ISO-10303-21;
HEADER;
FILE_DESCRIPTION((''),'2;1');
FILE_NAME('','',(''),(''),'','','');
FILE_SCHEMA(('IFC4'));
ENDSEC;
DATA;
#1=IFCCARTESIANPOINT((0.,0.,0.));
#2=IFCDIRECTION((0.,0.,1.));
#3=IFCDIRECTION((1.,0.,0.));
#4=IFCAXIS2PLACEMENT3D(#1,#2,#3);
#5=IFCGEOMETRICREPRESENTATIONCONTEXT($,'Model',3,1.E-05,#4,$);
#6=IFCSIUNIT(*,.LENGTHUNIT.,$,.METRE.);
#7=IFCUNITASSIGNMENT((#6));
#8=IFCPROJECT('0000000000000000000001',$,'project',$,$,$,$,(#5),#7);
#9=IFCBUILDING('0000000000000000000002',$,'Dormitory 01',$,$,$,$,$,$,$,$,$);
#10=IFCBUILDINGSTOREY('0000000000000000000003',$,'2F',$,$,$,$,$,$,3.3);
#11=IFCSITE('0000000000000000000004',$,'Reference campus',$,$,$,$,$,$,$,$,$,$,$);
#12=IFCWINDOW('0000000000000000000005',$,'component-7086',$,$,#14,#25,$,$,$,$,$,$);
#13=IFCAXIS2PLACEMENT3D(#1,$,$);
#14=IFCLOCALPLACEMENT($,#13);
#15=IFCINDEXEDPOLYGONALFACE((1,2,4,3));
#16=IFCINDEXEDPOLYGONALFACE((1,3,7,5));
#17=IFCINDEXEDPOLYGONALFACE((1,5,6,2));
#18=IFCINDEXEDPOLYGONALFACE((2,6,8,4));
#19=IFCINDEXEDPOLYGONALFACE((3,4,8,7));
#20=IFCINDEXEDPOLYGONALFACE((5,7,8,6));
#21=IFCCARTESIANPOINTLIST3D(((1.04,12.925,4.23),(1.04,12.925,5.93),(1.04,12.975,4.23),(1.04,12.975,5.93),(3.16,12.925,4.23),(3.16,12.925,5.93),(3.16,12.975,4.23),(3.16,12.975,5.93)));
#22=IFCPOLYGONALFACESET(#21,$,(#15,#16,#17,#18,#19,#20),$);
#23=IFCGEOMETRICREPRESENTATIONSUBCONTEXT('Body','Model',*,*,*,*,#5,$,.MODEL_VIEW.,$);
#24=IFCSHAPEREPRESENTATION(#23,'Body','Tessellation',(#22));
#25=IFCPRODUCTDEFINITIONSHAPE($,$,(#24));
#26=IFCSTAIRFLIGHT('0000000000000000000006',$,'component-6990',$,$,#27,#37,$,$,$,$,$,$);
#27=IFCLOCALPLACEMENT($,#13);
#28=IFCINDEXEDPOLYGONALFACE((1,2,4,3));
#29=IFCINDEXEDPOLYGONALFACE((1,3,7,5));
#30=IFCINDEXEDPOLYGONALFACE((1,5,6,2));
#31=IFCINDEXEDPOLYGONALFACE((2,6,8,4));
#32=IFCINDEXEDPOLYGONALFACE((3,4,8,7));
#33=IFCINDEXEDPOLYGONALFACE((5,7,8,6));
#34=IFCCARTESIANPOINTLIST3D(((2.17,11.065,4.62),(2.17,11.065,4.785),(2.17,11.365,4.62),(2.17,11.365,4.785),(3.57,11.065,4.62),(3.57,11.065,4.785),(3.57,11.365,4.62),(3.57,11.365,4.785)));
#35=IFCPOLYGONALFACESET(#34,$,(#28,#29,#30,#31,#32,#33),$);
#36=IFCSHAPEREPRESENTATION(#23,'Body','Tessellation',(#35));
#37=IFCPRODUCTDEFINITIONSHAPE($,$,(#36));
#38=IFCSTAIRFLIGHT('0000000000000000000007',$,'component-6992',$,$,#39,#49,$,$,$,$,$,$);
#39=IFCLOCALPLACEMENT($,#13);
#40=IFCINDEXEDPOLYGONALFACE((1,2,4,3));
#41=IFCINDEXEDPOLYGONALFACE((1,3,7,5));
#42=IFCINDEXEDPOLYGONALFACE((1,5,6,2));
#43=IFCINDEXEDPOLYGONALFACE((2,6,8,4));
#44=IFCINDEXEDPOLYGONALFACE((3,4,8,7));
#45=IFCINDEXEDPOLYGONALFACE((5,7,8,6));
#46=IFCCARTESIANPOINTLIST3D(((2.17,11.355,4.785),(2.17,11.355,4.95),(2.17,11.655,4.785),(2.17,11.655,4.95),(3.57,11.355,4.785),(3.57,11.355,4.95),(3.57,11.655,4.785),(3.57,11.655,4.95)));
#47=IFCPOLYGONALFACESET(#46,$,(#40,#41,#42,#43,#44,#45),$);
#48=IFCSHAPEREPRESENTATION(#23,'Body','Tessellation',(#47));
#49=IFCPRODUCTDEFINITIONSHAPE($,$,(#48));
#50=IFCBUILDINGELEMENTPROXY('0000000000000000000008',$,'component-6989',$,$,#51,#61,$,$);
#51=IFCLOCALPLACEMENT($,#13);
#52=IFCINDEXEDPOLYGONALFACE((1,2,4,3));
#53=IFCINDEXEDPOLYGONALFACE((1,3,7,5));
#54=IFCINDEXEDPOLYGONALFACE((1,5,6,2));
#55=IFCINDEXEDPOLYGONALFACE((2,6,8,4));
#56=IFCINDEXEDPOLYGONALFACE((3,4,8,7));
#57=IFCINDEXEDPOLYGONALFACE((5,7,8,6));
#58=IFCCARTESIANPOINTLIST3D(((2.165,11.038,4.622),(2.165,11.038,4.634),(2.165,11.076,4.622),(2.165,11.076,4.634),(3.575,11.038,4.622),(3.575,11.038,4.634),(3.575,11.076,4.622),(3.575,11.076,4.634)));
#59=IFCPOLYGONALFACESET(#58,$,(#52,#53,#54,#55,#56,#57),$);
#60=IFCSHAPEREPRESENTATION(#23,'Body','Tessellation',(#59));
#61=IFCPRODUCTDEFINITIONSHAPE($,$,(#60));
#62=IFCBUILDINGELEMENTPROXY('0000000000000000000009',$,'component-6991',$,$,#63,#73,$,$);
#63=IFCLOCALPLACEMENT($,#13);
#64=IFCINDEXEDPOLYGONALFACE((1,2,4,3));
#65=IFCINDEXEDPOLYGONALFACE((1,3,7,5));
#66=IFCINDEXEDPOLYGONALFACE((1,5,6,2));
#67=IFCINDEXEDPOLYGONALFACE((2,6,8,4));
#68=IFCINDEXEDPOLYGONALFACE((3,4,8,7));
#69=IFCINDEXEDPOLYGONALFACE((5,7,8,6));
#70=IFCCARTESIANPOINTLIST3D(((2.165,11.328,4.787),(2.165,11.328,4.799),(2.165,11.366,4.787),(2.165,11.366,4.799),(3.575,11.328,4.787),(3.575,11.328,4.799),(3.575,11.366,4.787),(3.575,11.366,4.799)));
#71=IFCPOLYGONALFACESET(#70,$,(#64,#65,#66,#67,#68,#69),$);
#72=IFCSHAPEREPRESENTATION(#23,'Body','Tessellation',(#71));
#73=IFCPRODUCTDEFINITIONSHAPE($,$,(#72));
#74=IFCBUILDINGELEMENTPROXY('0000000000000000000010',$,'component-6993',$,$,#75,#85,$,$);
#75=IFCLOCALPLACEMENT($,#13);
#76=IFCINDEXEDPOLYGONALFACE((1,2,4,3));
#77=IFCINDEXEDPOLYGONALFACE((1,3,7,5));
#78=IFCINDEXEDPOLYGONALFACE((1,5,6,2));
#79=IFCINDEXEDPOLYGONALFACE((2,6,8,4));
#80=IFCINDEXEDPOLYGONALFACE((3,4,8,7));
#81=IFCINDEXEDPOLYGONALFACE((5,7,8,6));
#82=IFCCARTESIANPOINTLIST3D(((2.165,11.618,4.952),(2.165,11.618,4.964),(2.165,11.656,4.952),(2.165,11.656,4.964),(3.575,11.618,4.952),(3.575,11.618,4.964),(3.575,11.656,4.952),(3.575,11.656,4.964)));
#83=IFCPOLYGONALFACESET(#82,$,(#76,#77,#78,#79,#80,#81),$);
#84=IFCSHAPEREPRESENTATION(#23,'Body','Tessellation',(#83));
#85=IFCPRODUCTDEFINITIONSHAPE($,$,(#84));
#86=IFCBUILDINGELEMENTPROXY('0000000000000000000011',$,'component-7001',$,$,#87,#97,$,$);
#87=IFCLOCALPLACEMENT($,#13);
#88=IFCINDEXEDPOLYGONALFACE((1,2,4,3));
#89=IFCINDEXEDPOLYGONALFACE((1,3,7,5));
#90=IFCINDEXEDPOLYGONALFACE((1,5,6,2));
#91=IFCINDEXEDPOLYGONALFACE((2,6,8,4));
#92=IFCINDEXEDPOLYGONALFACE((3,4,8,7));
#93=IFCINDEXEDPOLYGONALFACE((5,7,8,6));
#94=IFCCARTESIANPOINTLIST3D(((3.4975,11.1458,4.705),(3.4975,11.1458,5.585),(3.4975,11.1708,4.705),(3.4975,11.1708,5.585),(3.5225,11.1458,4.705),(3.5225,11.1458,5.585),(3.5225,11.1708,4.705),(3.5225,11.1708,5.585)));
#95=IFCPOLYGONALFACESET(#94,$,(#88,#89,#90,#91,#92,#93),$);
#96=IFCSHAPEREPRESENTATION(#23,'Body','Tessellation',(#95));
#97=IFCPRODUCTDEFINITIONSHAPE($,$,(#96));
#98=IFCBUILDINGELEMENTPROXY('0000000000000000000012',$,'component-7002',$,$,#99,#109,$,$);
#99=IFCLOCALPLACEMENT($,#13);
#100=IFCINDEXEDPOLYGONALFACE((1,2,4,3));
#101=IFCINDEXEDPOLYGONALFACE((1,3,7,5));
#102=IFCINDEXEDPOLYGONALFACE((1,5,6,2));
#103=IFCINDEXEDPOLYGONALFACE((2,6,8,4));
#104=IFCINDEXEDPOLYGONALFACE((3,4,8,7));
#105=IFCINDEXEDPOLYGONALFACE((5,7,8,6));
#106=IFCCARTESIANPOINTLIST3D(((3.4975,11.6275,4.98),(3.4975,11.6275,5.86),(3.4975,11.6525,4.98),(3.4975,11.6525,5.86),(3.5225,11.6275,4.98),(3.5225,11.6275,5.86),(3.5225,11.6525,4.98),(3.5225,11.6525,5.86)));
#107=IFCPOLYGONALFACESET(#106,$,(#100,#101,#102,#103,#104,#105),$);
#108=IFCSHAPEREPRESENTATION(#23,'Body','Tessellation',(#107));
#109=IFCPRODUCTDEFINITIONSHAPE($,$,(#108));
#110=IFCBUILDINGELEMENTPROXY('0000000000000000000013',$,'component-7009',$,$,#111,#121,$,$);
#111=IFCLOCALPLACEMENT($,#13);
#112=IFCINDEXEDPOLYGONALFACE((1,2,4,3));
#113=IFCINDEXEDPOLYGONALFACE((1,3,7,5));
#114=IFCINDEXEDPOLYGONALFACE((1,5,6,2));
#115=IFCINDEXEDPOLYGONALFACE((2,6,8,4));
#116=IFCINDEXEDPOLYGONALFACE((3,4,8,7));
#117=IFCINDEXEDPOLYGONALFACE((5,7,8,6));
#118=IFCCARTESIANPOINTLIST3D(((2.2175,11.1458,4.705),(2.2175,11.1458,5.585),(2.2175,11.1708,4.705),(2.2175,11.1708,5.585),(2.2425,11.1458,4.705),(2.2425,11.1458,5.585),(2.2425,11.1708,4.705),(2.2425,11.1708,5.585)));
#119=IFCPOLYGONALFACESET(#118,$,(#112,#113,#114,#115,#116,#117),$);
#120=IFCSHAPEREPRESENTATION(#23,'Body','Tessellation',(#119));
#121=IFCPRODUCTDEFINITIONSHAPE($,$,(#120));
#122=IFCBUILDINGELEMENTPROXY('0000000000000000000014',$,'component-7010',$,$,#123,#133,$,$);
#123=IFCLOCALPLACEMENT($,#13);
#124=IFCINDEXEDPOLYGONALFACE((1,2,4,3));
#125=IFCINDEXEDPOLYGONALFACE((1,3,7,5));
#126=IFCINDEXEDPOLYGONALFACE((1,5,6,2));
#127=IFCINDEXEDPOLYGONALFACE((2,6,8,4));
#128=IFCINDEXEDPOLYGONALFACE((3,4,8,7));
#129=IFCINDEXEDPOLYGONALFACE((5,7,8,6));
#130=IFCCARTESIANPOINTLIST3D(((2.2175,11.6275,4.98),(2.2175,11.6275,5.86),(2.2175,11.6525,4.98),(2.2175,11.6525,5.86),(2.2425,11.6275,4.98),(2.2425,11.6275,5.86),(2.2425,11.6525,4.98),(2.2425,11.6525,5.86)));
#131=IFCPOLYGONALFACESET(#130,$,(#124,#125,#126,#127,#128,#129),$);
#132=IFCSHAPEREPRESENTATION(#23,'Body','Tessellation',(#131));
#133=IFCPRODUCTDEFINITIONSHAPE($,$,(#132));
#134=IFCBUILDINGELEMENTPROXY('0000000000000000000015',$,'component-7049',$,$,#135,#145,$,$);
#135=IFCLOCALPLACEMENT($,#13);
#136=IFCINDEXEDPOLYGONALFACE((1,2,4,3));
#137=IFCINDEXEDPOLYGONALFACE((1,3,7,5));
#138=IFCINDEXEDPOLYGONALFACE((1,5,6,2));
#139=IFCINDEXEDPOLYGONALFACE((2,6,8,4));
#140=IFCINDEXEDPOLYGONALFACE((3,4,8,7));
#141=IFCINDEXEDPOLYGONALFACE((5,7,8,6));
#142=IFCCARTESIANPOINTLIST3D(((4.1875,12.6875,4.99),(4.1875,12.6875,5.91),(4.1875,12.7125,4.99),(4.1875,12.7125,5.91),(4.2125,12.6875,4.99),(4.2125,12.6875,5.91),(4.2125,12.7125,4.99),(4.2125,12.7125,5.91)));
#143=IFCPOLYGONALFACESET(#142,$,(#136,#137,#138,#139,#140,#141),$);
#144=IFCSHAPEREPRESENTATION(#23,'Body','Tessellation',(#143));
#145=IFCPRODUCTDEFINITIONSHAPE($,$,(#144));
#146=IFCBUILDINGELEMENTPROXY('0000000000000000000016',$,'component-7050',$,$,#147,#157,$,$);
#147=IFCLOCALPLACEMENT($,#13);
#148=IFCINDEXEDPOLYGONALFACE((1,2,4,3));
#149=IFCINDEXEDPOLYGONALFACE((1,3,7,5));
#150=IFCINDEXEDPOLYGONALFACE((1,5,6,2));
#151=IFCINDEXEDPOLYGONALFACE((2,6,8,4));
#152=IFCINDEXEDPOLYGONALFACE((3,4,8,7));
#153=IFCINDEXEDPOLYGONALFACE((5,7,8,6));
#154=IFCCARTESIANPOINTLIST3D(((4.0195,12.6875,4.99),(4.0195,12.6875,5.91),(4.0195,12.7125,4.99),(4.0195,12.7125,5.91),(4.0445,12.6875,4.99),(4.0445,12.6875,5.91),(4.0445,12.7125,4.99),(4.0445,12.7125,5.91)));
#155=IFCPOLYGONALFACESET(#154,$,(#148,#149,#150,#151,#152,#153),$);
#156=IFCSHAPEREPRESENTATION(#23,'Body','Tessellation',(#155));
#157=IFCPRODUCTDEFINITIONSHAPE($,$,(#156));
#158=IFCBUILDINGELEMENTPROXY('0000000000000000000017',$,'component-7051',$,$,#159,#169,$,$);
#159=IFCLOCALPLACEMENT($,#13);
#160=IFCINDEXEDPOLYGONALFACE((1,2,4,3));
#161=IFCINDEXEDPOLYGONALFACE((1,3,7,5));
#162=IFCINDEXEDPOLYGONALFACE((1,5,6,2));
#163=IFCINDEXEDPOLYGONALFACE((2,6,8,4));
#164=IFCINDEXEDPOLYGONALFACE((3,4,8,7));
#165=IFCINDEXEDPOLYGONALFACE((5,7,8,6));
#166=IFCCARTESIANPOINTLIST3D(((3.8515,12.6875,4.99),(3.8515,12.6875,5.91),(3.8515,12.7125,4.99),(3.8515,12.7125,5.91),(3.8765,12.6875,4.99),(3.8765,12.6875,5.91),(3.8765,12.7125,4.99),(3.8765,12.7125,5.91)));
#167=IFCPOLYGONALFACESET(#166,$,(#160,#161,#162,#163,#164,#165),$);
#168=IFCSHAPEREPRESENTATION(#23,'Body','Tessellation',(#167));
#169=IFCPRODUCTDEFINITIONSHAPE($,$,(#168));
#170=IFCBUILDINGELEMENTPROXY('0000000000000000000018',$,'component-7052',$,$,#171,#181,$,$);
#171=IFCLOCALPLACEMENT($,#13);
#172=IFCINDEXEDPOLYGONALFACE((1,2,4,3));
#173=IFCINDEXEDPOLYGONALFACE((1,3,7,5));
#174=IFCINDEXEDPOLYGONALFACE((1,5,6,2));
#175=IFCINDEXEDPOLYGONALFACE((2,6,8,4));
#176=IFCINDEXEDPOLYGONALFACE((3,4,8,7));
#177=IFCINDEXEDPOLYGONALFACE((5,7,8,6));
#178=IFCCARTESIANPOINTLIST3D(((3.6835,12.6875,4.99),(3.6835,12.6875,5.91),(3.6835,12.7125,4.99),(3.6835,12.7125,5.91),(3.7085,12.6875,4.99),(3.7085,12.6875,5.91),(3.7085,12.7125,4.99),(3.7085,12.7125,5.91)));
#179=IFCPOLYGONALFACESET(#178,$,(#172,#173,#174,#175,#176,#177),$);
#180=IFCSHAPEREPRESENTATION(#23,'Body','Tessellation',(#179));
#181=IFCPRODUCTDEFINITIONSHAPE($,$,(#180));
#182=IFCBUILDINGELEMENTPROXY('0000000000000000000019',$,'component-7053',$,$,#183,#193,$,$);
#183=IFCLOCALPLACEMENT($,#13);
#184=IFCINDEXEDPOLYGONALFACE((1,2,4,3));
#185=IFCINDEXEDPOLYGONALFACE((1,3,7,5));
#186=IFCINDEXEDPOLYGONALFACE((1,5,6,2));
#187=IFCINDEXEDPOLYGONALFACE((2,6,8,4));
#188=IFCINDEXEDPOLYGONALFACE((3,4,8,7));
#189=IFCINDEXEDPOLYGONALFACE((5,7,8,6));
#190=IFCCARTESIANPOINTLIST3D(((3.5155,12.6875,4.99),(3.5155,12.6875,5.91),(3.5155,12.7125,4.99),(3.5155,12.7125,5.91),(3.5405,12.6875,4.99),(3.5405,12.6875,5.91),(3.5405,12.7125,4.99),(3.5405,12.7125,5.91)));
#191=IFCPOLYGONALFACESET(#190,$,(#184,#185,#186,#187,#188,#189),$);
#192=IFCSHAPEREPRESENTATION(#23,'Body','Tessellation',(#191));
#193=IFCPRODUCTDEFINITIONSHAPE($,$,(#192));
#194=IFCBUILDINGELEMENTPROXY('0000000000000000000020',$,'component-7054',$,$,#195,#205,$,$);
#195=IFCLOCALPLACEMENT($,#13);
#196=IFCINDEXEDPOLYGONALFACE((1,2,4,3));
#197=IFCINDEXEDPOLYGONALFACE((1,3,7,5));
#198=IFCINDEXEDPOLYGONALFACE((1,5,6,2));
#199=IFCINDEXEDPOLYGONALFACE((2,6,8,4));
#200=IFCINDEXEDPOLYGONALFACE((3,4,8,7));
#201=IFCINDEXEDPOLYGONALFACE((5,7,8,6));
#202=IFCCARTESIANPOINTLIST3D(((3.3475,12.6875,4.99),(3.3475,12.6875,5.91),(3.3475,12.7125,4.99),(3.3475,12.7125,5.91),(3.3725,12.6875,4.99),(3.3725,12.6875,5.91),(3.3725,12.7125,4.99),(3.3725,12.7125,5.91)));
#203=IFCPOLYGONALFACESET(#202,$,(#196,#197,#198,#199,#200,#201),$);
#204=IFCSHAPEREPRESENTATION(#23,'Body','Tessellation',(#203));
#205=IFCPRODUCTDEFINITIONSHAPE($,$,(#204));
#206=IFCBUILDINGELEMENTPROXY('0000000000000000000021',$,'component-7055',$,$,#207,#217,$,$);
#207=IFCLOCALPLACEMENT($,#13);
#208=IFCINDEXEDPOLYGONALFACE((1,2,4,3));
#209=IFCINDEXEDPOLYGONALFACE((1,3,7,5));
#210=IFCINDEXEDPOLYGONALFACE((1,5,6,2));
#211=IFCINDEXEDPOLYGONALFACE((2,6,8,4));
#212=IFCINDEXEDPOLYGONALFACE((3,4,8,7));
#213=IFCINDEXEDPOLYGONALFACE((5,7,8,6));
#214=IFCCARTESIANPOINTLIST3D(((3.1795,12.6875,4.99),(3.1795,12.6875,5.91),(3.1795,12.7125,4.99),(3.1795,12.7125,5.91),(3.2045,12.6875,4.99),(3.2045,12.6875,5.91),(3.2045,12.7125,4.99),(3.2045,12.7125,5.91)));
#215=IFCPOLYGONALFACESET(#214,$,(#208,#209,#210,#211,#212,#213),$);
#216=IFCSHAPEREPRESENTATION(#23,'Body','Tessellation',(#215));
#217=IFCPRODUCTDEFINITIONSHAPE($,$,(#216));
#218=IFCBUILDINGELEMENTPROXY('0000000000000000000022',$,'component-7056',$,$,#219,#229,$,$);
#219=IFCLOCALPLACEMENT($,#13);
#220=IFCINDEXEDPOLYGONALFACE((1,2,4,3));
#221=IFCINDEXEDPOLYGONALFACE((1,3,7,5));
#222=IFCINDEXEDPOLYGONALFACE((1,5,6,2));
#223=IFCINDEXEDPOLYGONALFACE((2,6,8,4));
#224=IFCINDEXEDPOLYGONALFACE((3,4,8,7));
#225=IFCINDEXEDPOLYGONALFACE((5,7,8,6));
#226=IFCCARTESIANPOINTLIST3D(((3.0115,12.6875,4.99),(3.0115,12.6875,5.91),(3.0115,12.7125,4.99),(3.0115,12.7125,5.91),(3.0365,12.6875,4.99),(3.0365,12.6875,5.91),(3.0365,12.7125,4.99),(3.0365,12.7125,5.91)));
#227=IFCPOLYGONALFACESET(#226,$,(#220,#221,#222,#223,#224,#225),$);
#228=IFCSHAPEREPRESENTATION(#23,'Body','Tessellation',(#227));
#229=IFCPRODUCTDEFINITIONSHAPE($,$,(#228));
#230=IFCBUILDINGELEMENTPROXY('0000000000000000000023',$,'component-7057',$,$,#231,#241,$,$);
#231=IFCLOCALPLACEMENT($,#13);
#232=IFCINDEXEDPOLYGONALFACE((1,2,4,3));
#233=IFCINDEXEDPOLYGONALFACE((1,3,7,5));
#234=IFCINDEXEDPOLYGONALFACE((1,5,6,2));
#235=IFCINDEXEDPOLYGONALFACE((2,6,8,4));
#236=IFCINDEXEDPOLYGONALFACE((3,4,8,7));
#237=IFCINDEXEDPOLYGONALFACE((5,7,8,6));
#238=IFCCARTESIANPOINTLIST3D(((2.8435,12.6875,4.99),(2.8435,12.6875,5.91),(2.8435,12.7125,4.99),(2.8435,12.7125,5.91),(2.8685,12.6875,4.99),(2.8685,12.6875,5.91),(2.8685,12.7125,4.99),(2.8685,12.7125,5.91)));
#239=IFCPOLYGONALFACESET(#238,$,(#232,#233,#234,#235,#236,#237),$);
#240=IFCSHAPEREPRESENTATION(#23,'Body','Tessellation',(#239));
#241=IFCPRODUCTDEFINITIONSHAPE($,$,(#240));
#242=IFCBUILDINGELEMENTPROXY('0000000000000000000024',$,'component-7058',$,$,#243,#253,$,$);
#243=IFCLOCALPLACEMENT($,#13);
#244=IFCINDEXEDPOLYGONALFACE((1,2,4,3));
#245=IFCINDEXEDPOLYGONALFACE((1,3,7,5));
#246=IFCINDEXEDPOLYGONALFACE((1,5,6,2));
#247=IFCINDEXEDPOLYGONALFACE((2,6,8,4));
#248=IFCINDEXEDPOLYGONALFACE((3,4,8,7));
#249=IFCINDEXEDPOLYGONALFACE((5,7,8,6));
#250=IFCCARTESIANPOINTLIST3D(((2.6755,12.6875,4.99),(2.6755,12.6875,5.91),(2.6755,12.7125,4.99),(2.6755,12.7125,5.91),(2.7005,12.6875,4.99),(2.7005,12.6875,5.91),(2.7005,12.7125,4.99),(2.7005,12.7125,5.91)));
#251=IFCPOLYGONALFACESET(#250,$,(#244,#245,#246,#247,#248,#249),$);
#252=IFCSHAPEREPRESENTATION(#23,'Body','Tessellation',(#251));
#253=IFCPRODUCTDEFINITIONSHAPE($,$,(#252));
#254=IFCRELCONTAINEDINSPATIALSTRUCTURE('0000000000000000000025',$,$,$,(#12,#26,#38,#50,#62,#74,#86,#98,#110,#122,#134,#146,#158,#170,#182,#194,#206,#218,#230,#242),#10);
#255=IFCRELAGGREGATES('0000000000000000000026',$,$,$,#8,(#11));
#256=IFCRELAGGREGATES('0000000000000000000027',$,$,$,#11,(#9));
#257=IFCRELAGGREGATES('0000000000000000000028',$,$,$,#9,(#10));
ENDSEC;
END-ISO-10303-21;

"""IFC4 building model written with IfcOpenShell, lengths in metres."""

from ifc_helpers import new_model, si_unit, frame, origin, origin_with_axes, origin_2d, place, context, subcontext, project, spatial, rectangle, extrude, element, save


model = new_model("IFC4")

# Units and contexts
model_context = context("Model", 3, precision=1e-05, world=origin_with_axes())
body_context = subcontext(model_context, "Body", "Model", "MODEL_VIEW")
ifc_project = project(units=[si_unit("LENGTHUNIT", "METRE")], contexts=[model_context])

# Site, building, storey
site = spatial("IfcSite", under=ifc_project, Name="Reference campus")
building = spatial("IfcBuilding", under=site, Name="Dormitory 01")
storey = spatial("IfcBuildingStorey", under=building, Name="2F", Elevation=3.3)

# Window
window_placement = place(None, frame((2.1, 12.95, 4.23), z_axis=(0.0, 0.0, 1.0), x_axis=(-1.0, 0.0, 0.0)))
element("IfcWindow", 1, at=window_placement, inside=storey, Name="component-7086", context=body_context, shape_type="SweptSolid", body=[
    extrude(rectangle(XDim=2.12, YDim=0.05, at=origin_2d()), origin(), (0.0, 0.0, 1.0), 1.7),
])

# Stair flights
for number, where, z_axis, x_axis, name in (
    (2, (2.87, 11.215, 4.62), (0.0, 0.0, 1.0), (-1.0, 0.0, 0.0), "component-6990"),
    (3, (2.87, 11.505, 4.785), (0.0, 0.0, 1.0), (-1.0, 0.0, 0.0), "component-6992"),
):
    element("IfcStairFlight", number, at=place(None, frame(where, z_axis=z_axis, x_axis=x_axis)), inside=storey, Name=name, context=body_context, shape_type="SweptSolid", body=[
        extrude(rectangle(XDim=1.4, YDim=0.3, at=origin_2d()), origin(), (0.0, 0.0, 1.0), 0.165),
    ])

# Building element proxies
for number, where, z_axis, x_axis, name in (
    (4, (2.87, 11.057, 4.622), (0.0, 0.0, 1.0), (-1.0, 0.0, 0.0), "component-6989"),
    (5, (2.87, 11.347, 4.787), (0.0, 0.0, 1.0), (-1.0, 0.0, 0.0), "component-6991"),
    (6, (2.87, 11.637, 4.952), (0.0, 0.0, 1.0), (-1.0, 0.0, 0.0), "component-6993"),
):
    element("IfcBuildingElementProxy", number, at=place(None, frame(where, z_axis=z_axis, x_axis=x_axis)), inside=storey, Name=name, context=body_context, shape_type="SweptSolid", body=[
        extrude(rectangle(XDim=1.41, YDim=0.038, at=origin_2d()), origin(), (0.0, 0.0, 1.0), 0.012),
    ])
for number, where, z_axis, x_axis, name in (
    (7, (3.51, 11.1583, 4.705), (0.0, 0.0, 1.0), (-1.0, 0.0, 0.0), "component-7001"),
    (8, (3.51, 11.64, 4.98), (0.0, 0.0, 1.0), (-1.0, 0.0, 0.0), "component-7002"),
    (9, (2.23, 11.1583, 4.705), (0.0, 0.0, 1.0), (-1.0, 0.0, 0.0), "component-7009"),
    (10, (2.23, 11.64, 4.98), (0.0, 0.0, 1.0), (-1.0, 0.0, 0.0), "component-7010"),
):
    element("IfcBuildingElementProxy", number, at=place(None, frame(where, z_axis=z_axis, x_axis=x_axis)), inside=storey, Name=name, context=body_context, shape_type="SweptSolid", body=[
        extrude(rectangle(XDim=0.025, YDim=0.025, at=origin_2d()), origin(), (0.0, 0.0, 1.0), 0.88),
    ])
for number, where, z_axis, x_axis, name in (
    (11, (4.2, 12.7, 4.99), (0.0, 0.0, 1.0), (-1.0, 0.0, 0.0), "component-7049"),
    (12, (4.032, 12.7, 4.99), (0.0, 0.0, 1.0), (-1.0, 0.0, 0.0), "component-7050"),
    (13, (3.864, 12.7, 4.99), (0.0, 0.0, 1.0), (-1.0, 0.0, 0.0), "component-7051"),
    (14, (3.696, 12.7, 4.99), (0.0, 0.0, 1.0), (-1.0, 0.0, 0.0), "component-7052"),
    (15, (3.528, 12.7, 4.99), (0.0, 0.0, 1.0), (-1.0, 0.0, 0.0), "component-7053"),
    (16, (3.36, 12.7, 4.99), (0.0, 0.0, 1.0), (-1.0, 0.0, 0.0), "component-7054"),
    (17, (3.192, 12.7, 4.99), (0.0, 0.0, 1.0), (-1.0, 0.0, 0.0), "component-7055"),
    (18, (3.024, 12.7, 4.99), (0.0, 0.0, 1.0), (-1.0, 0.0, 0.0), "component-7056"),
    (19, (2.856, 12.7, 4.99), (0.0, 0.0, 1.0), (-1.0, 0.0, 0.0), "component-7057"),
    (20, (2.688, 12.7, 4.99), (0.0, 0.0, 1.0), (-1.0, 0.0, 0.0), "component-7058"),
):
    element("IfcBuildingElementProxy", number, at=place(None, frame(where, z_axis=z_axis, x_axis=x_axis)), inside=storey, Name=name, context=body_context, shape_type="SweptSolid", body=[
        extrude(rectangle(XDim=0.025, YDim=0.025, at=origin_2d()), origin(), (0.0, 0.0, 1.0), 0.92),
    ])

save(model, "model.ifc")
